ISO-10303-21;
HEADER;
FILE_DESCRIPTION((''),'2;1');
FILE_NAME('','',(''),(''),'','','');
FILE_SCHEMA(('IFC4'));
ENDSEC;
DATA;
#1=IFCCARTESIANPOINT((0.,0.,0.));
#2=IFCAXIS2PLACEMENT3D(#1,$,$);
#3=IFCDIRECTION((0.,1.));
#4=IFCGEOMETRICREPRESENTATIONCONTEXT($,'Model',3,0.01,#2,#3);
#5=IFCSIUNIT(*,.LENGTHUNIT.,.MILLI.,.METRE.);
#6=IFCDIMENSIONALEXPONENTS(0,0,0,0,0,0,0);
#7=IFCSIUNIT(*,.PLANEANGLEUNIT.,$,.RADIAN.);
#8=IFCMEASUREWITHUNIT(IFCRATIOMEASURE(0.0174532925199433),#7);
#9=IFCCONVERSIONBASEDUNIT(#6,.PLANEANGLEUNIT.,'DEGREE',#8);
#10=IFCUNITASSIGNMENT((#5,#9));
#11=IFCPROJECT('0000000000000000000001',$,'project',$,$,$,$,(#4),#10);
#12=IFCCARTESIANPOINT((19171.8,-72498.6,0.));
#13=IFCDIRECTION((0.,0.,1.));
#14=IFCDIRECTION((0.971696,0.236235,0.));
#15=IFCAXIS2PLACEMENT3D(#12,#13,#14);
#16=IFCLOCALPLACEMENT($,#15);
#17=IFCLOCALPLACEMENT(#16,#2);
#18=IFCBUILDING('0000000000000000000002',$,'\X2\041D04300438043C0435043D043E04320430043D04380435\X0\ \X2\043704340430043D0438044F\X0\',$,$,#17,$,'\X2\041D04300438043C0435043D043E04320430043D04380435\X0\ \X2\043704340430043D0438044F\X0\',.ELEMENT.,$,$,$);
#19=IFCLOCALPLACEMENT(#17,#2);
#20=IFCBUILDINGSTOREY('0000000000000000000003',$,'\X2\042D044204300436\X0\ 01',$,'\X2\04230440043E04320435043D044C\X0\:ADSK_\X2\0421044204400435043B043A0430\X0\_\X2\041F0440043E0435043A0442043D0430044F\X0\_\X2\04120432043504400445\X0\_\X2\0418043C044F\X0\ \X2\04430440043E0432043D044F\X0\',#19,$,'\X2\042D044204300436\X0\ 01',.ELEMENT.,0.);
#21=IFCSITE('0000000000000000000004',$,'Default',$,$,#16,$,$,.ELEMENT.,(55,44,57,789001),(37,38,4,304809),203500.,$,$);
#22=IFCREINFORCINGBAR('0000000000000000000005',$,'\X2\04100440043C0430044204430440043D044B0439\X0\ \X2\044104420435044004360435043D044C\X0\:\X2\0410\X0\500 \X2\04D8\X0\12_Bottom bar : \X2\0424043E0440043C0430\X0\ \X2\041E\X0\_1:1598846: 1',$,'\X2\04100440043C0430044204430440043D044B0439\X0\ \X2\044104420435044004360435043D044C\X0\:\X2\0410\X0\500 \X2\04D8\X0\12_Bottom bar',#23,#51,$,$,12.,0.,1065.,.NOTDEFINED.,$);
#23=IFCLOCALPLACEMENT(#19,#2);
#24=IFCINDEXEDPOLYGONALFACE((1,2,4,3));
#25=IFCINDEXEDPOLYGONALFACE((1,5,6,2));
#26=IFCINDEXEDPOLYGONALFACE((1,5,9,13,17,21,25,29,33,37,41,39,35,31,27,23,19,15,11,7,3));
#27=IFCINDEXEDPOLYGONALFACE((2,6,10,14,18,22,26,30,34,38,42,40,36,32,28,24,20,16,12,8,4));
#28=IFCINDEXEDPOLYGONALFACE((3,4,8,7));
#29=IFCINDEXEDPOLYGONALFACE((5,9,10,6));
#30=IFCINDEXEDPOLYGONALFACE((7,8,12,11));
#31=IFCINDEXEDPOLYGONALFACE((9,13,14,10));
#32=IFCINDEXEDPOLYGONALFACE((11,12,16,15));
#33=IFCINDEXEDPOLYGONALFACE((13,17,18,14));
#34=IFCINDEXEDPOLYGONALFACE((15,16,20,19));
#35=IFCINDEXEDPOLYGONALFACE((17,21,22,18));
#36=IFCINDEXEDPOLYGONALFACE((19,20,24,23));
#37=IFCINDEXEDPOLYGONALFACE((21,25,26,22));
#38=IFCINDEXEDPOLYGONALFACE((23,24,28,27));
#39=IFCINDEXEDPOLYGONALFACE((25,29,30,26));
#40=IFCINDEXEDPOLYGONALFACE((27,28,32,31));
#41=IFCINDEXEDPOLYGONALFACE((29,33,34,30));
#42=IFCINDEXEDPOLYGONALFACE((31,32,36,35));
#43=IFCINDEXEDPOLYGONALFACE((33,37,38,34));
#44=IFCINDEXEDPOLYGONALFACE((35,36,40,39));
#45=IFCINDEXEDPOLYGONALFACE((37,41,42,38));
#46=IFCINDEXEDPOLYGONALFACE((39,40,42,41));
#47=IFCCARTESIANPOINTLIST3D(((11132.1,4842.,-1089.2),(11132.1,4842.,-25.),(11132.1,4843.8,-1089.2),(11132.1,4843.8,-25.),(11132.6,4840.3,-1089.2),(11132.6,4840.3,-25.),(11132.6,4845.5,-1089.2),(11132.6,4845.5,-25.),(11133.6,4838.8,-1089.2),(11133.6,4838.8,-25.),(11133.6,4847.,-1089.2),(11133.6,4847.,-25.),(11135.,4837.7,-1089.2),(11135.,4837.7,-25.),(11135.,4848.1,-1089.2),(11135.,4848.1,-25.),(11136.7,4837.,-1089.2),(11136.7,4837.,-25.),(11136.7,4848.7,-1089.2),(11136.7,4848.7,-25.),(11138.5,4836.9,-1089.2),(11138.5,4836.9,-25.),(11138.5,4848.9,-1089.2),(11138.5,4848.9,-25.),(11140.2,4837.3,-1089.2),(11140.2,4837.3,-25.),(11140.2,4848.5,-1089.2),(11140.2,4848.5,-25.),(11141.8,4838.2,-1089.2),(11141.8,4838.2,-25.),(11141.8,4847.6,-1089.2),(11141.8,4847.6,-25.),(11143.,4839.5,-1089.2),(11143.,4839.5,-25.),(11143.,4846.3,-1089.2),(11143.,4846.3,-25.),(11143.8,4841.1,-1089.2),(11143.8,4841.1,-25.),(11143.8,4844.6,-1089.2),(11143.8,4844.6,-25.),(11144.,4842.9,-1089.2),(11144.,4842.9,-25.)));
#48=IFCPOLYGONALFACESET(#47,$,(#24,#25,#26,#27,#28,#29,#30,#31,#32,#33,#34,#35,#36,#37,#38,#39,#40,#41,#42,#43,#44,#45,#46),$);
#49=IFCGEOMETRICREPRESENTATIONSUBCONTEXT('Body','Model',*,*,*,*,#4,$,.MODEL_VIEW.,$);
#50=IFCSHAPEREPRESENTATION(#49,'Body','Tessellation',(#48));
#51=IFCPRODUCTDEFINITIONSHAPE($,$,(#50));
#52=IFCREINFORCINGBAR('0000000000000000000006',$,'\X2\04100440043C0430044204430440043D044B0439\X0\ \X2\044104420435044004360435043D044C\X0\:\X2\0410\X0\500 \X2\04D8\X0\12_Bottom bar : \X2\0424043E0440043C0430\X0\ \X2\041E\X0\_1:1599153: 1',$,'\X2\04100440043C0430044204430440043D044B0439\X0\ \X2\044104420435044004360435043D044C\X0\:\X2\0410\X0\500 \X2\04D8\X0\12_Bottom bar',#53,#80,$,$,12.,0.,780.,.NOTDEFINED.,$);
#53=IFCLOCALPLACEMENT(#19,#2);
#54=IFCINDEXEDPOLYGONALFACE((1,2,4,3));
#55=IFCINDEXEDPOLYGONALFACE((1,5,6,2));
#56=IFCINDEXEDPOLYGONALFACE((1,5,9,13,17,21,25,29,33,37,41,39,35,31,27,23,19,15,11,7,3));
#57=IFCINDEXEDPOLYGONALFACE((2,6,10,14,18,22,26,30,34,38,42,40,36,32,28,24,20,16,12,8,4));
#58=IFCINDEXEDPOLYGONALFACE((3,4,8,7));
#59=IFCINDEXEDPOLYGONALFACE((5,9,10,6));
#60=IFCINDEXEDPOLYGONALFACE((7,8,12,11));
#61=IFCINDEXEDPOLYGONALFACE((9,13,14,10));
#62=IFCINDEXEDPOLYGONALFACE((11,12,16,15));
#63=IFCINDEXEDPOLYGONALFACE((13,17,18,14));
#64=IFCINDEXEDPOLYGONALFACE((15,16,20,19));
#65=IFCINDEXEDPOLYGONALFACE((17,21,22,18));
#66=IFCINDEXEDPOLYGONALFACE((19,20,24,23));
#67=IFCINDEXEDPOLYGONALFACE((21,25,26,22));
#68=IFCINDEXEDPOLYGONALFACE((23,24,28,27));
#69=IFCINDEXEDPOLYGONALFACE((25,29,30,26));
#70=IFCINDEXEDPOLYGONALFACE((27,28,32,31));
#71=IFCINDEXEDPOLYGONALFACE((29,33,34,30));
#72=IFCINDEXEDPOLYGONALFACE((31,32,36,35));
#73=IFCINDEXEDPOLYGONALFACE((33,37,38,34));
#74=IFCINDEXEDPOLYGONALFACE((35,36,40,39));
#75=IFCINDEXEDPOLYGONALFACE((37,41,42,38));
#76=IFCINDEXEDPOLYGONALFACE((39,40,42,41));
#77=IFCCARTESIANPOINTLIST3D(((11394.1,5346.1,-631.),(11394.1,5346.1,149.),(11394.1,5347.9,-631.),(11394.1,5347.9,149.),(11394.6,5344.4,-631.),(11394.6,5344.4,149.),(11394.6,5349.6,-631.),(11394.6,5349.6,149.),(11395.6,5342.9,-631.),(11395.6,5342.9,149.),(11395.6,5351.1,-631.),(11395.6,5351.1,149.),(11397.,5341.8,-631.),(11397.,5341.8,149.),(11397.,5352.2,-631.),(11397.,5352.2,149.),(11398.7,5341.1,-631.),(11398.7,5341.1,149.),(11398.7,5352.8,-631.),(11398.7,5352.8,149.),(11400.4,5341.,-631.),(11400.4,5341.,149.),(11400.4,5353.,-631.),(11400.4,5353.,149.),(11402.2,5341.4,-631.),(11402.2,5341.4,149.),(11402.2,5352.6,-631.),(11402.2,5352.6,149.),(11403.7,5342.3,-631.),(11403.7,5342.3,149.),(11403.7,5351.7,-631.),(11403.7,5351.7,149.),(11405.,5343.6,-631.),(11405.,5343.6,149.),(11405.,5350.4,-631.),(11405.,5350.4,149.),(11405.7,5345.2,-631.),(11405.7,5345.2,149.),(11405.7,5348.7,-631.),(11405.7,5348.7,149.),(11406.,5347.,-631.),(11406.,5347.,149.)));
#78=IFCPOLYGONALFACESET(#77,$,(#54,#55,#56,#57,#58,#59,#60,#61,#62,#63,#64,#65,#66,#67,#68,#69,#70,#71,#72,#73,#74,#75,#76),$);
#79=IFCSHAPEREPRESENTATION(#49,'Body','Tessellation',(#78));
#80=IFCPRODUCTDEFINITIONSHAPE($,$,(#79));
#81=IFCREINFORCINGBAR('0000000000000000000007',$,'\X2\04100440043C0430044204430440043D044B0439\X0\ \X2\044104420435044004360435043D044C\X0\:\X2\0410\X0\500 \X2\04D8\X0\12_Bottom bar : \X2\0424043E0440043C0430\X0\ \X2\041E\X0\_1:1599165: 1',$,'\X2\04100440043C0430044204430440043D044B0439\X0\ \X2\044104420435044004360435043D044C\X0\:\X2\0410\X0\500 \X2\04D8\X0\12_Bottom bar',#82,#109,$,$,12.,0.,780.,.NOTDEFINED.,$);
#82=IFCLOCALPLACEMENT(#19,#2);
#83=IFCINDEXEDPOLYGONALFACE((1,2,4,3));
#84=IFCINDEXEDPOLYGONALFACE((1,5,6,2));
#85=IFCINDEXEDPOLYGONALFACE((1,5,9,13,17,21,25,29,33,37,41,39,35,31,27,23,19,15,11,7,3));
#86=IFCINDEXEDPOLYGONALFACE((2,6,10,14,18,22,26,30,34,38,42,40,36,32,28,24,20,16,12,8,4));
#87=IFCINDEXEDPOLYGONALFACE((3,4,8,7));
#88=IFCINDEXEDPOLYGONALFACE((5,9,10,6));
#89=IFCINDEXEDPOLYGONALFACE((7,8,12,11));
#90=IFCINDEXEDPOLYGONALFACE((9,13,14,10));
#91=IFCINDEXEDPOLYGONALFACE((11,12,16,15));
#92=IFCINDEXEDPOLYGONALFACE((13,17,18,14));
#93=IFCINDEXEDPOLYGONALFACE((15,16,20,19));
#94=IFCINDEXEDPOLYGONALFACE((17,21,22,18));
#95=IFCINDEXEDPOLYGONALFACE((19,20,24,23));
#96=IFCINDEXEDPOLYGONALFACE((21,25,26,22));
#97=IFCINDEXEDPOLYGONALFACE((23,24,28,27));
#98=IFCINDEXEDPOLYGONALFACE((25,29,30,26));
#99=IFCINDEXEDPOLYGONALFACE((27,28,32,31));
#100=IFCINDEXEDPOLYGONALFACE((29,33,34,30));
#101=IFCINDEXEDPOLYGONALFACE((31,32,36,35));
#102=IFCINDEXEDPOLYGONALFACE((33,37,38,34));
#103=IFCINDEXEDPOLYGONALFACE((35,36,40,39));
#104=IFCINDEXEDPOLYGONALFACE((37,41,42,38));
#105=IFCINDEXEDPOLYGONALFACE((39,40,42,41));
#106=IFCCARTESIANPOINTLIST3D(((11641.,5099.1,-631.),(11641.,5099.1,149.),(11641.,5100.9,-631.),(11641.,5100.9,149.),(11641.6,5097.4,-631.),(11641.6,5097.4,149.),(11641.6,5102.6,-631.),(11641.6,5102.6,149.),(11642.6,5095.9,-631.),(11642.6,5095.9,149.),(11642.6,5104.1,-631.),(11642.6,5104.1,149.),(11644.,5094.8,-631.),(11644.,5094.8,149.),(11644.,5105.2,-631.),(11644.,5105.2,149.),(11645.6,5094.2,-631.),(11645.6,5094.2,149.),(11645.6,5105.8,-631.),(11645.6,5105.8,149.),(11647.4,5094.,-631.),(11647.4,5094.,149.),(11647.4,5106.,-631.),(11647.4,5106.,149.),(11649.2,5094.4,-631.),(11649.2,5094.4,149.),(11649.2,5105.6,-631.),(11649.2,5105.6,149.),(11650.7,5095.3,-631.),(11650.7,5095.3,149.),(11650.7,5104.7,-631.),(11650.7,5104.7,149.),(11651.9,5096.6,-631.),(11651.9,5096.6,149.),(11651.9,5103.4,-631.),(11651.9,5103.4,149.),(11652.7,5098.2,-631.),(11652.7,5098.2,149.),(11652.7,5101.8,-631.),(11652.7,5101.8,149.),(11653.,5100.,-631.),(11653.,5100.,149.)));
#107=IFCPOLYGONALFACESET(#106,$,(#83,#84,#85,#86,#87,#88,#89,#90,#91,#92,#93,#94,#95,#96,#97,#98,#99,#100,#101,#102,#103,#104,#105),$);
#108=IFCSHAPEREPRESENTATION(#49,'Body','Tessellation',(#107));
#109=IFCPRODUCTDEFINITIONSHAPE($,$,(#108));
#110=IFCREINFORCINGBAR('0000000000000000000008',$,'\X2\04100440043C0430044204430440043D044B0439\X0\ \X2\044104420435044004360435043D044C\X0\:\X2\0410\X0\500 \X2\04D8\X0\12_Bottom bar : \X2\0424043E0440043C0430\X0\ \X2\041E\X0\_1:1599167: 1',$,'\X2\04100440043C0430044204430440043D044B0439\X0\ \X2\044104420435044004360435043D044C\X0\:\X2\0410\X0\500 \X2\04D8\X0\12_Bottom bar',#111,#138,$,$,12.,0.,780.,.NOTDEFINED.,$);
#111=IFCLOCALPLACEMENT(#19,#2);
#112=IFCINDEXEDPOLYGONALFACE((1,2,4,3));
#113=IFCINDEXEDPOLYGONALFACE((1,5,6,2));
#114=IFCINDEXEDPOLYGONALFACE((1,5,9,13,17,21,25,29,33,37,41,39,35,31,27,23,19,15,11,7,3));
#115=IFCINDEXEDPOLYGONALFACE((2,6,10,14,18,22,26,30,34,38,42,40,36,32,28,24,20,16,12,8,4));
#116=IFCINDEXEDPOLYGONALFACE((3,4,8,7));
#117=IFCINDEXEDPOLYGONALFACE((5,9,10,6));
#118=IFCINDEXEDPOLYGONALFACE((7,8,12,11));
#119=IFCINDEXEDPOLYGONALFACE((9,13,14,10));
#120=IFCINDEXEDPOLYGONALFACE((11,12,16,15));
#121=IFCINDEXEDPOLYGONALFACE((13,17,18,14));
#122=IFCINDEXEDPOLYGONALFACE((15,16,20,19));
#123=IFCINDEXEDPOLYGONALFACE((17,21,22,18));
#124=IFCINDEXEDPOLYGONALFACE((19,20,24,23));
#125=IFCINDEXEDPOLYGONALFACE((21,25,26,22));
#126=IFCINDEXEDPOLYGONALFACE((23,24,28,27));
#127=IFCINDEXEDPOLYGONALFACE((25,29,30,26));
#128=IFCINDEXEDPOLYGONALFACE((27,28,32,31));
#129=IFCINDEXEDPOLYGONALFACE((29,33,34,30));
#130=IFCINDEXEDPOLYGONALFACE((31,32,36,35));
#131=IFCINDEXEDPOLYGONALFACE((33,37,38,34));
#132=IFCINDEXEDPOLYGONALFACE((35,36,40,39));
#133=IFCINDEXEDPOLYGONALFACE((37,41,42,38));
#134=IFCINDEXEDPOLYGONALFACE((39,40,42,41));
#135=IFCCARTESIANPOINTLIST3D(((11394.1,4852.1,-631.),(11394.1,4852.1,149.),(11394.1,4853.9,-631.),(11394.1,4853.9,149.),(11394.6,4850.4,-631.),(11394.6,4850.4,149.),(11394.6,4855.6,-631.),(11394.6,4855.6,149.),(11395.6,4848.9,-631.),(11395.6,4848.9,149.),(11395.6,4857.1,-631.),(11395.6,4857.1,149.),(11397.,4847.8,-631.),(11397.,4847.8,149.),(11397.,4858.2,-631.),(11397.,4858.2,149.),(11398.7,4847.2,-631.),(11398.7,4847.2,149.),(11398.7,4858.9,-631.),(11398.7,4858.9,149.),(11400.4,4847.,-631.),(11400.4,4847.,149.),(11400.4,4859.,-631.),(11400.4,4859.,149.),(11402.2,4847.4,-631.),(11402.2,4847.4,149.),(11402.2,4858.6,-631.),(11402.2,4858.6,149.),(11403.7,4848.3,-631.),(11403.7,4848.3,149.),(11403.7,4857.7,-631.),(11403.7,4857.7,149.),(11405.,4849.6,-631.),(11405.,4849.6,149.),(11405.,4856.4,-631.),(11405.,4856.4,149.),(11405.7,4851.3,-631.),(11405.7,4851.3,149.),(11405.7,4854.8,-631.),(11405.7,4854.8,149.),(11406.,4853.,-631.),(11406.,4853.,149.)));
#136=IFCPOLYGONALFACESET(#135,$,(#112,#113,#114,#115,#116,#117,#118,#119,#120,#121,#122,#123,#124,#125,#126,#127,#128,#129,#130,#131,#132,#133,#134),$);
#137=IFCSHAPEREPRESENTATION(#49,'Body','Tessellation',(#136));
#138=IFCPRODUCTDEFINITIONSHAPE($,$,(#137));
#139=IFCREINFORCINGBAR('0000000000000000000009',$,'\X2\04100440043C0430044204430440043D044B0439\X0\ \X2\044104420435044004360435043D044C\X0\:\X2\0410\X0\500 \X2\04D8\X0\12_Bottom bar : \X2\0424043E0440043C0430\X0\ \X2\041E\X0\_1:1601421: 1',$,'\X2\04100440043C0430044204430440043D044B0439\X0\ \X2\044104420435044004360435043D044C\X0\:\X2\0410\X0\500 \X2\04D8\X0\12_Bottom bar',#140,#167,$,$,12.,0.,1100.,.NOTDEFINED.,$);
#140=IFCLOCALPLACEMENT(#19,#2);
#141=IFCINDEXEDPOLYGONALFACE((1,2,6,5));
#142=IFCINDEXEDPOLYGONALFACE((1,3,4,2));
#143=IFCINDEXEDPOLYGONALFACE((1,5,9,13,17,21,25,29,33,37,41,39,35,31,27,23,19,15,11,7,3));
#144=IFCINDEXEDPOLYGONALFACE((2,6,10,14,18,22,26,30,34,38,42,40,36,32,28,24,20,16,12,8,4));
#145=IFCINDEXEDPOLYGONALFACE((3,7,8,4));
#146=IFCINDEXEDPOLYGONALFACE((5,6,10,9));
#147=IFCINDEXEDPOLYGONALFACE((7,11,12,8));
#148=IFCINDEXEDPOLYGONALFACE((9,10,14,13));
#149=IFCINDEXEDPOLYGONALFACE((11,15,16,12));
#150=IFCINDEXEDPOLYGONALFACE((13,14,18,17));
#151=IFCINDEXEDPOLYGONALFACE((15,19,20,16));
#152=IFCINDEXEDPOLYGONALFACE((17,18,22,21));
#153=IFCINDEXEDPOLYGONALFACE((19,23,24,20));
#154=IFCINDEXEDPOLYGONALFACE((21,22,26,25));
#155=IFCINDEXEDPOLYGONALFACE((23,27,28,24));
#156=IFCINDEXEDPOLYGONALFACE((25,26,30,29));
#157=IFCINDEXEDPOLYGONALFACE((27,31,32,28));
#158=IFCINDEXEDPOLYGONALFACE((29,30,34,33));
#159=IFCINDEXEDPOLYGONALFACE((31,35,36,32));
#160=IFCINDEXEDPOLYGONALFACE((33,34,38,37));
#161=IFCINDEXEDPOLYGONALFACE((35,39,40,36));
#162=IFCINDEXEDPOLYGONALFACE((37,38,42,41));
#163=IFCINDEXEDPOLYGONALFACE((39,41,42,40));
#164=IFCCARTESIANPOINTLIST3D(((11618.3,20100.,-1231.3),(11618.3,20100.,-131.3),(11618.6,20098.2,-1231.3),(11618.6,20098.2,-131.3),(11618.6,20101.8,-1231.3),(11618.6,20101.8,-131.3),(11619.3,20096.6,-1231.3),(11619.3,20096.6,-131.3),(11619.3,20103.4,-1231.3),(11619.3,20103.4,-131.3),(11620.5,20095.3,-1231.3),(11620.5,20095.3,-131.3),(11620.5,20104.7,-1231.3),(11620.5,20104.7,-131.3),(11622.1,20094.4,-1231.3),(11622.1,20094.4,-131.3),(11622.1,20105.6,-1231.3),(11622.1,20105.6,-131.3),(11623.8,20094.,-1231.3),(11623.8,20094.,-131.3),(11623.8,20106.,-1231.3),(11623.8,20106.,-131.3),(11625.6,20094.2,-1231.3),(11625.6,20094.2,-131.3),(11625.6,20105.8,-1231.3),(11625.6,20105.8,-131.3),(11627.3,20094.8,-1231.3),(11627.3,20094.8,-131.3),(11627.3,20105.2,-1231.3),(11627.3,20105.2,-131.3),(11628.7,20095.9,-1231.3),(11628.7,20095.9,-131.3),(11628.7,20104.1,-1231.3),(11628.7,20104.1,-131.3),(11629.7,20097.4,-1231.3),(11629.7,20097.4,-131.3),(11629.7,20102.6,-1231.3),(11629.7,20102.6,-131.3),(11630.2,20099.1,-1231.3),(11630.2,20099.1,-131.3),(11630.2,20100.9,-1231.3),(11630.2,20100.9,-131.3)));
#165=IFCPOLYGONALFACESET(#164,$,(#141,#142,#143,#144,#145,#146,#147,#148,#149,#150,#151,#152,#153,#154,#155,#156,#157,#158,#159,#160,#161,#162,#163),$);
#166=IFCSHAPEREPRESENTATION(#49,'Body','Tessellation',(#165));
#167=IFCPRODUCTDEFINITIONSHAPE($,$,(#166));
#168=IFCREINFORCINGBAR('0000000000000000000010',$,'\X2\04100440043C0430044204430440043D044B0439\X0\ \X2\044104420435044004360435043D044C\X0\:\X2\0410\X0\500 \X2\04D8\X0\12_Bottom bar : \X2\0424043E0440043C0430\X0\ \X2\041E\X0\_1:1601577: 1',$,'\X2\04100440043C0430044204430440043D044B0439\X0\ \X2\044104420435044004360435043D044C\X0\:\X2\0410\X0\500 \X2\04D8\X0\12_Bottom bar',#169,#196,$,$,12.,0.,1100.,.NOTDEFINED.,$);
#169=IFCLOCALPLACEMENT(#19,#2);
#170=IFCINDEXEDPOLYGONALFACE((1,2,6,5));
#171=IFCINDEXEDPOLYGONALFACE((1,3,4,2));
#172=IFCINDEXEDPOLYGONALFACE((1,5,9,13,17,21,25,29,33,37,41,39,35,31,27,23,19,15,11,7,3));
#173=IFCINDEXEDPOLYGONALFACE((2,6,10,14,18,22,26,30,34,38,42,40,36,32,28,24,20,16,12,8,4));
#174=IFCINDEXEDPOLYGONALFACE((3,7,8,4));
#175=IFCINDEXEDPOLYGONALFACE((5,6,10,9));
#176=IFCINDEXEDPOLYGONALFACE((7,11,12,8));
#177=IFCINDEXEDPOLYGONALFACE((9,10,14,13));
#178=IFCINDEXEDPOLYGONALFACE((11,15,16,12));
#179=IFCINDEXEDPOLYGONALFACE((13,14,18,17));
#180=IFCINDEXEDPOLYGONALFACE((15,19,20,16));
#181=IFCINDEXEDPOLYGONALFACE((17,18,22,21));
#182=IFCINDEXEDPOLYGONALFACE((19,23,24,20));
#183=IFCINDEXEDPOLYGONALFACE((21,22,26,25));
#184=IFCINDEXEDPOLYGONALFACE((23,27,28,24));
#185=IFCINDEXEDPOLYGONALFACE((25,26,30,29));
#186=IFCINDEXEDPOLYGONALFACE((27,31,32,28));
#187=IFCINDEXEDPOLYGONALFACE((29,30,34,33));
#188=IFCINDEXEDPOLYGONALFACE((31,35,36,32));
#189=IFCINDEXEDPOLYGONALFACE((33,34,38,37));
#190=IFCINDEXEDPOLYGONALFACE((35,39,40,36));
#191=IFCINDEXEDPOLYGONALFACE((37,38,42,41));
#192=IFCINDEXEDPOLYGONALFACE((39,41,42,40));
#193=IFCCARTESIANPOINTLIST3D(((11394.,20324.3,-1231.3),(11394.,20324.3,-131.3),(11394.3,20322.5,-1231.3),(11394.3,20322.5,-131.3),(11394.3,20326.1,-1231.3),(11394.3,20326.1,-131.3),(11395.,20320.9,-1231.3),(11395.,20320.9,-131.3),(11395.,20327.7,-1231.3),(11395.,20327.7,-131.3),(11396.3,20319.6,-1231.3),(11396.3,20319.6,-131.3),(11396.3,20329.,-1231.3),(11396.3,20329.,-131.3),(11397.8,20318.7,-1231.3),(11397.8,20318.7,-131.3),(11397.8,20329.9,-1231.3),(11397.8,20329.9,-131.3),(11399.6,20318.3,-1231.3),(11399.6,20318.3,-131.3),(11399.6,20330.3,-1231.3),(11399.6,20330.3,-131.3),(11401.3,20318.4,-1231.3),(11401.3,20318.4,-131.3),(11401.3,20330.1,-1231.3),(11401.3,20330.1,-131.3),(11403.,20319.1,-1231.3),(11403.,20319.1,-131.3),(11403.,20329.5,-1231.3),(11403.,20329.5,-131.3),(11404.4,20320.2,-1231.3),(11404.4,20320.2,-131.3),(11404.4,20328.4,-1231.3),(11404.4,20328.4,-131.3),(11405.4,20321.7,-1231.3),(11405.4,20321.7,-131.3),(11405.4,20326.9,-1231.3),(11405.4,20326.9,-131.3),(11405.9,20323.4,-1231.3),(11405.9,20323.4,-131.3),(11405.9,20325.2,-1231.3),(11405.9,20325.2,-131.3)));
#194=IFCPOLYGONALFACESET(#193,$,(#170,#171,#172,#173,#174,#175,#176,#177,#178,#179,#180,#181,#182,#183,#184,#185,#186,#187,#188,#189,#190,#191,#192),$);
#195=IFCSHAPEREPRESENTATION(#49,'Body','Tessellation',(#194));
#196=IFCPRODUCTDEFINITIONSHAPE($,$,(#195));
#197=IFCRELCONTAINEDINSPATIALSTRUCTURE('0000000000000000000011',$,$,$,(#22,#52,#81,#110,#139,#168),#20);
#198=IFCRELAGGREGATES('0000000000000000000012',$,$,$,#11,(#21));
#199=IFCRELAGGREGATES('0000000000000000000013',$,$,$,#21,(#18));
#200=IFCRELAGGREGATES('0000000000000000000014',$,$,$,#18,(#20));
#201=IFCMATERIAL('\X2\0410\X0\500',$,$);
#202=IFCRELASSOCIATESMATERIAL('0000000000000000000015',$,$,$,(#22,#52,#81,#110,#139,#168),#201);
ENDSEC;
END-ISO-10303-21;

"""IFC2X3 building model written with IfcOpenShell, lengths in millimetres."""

from ifc_helpers import new_model, entity, si_unit, converted_unit, direction, frame, origin, place, context, subcontext, project, spatial, material, element, save


model = new_model("IFC2X3")

# Units and contexts
model_context = context("Model", 3, precision=0.01, world=origin(), true_north=direction((0.0, 1.0)))
body_context = subcontext(model_context, "Body", "Model", "MODEL_VIEW")
ifc_project = project(units=[si_unit("LENGTHUNIT", "METRE", prefix="MILLI"), converted_unit("PLANEANGLEUNIT", "DEGREE", entity("IfcRatioMeasure", 0.0174532925199433), si_unit("PLANEANGLEUNIT", "RADIAN"), dimensions=[0, 0, 0, 0, 0, 0, 0])], contexts=[model_context])

# Site, building, storey
site_placement = place(None, frame((19171.8, -72498.6, 0.0), z_axis=(0.0, 0.0, 1.0), x_axis=(0.971696, 0.236235, 0.0)))
site = spatial("IfcSite", under=ifc_project, at=site_placement, Name="Default", CompositionType="ELEMENT", RefLatitude=(55, 44, 57, 789001), RefLongitude=(37, 38, 4, 304809), RefElevation=203500.0)
building_placement = place(site_placement, origin())
building = spatial("IfcBuilding", under=site, at=building_placement, Name="Наименование здания", LongName="Наименование здания", CompositionType="ELEMENT")
storey_placement = place(building_placement, origin())
storey = spatial("IfcBuildingStorey", under=building, at=storey_placement, Name="Этаж 01", ObjectType="Уровень:ADSK_Стрелка_Проектная_Вверх_Имя уровня", LongName="Этаж 01", CompositionType="ELEMENT", Elevation=0.0)

# Reinforcing bars
ifc_material = material(Name="А500")
placement = place(storey_placement, origin())
element("IfcReinforcingBar", 1, at=placement, inside=storey, material=ifc_material, Name="Арматурный стержень:А500 Ә12_Bottom bar : Форма О_1:1598846: 1", ObjectType="Арматурный стержень:А500 Ә12_Bottom bar", BarLength=1065.0, BarRole="NOTDEFINED", CrossSectionArea=0.0, NominalDiameter=12.0, context=body_context, shape_type="AdvancedSweptSolid", body=[
    entity("IfcSweptDiskSolid", entity("IfcCompositeCurve", [entity("IfcCompositeCurveSegment", "CONTINUOUS", True, entity("IfcPolyline", [entity("IfcCartesianPoint", [11138.0, 4842.9, -1089.2]), entity("IfcCartesianPoint", [11138.0, 4842.9, -25.0])]))], False), 6.0, None, 0.0, 1.0),
])
element("IfcReinforcingBar", 2, at=placement, inside=storey, material=ifc_material, Name="Арматурный стержень:А500 Ә12_Bottom bar : Форма О_1:1599153: 1", ObjectType="Арматурный стержень:А500 Ә12_Bottom bar", BarLength=780.0, BarRole="NOTDEFINED", CrossSectionArea=0.0, NominalDiameter=12.0, context=body_context, shape_type="AdvancedSweptSolid", body=[
    entity("IfcSweptDiskSolid", entity("IfcCompositeCurve", [entity("IfcCompositeCurveSegment", "CONTINUOUS", True, entity("IfcPolyline", [entity("IfcCartesianPoint", [11400.0, 5347.0, -631.0]), entity("IfcCartesianPoint", [11400.0, 5347.0, 149.0])]))], False), 6.0, None, 0.0, 1.0),
])
element("IfcReinforcingBar", 3, at=placement, inside=storey, material=ifc_material, Name="Арматурный стержень:А500 Ә12_Bottom bar : Форма О_1:1599165: 1", ObjectType="Арматурный стержень:А500 Ә12_Bottom bar", BarLength=780.0, BarRole="NOTDEFINED", CrossSectionArea=0.0, NominalDiameter=12.0, context=body_context, shape_type="AdvancedSweptSolid", body=[
    entity("IfcSweptDiskSolid", entity("IfcCompositeCurve", [entity("IfcCompositeCurveSegment", "CONTINUOUS", True, entity("IfcPolyline", [entity("IfcCartesianPoint", [11647.0, 5100.0, -631.0]), entity("IfcCartesianPoint", [11647.0, 5100.0, 149.0])]))], False), 6.0, None, 0.0, 1.0),
])
element("IfcReinforcingBar", 4, at=placement, inside=storey, material=ifc_material, Name="Арматурный стержень:А500 Ә12_Bottom bar : Форма О_1:1599167: 1", ObjectType="Арматурный стержень:А500 Ә12_Bottom bar", BarLength=780.0, BarRole="NOTDEFINED", CrossSectionArea=0.0, NominalDiameter=12.0, context=body_context, shape_type="AdvancedSweptSolid", body=[
    entity("IfcSweptDiskSolid", entity("IfcCompositeCurve", [entity("IfcCompositeCurveSegment", "CONTINUOUS", True, entity("IfcPolyline", [entity("IfcCartesianPoint", [11400.0, 4853.0, -631.0]), entity("IfcCartesianPoint", [11400.0, 4853.0, 149.0])]))], False), 6.0, None, 0.0, 1.0),
])
element("IfcReinforcingBar", 5, at=placement, inside=storey, material=ifc_material, Name="Арматурный стержень:А500 Ә12_Bottom bar : Форма О_1:1601421: 1", ObjectType="Арматурный стержень:А500 Ә12_Bottom bar", BarLength=1100.0, BarRole="NOTDEFINED", CrossSectionArea=0.0, NominalDiameter=12.0, context=body_context, shape_type="AdvancedSweptSolid", body=[
    entity("IfcSweptDiskSolid", entity("IfcCompositeCurve", [entity("IfcCompositeCurveSegment", "CONTINUOUS", True, entity("IfcPolyline", [entity("IfcCartesianPoint", [11624.3, 20100.0, -131.3]), entity("IfcCartesianPoint", [11624.3, 20100.0, -1231.3])]))], False), 6.0, None, 0.0, 1.0),
])
element("IfcReinforcingBar", 6, at=placement, inside=storey, material=ifc_material, Name="Арматурный стержень:А500 Ә12_Bottom bar : Форма О_1:1601577: 1", ObjectType="Арматурный стержень:А500 Ә12_Bottom bar", BarLength=1100.0, BarRole="NOTDEFINED", CrossSectionArea=0.0, NominalDiameter=12.0, context=body_context, shape_type="AdvancedSweptSolid", body=[
    entity("IfcSweptDiskSolid", entity("IfcCompositeCurve", [entity("IfcCompositeCurveSegment", "CONTINUOUS", True, entity("IfcPolyline", [entity("IfcCartesianPoint", [11400.0, 20324.3, -131.3]), entity("IfcCartesianPoint", [11400.0, 20324.3, -1231.3])]))], False), 6.0, None, 0.0, 1.0),
])

save(model, "model.ifc")
